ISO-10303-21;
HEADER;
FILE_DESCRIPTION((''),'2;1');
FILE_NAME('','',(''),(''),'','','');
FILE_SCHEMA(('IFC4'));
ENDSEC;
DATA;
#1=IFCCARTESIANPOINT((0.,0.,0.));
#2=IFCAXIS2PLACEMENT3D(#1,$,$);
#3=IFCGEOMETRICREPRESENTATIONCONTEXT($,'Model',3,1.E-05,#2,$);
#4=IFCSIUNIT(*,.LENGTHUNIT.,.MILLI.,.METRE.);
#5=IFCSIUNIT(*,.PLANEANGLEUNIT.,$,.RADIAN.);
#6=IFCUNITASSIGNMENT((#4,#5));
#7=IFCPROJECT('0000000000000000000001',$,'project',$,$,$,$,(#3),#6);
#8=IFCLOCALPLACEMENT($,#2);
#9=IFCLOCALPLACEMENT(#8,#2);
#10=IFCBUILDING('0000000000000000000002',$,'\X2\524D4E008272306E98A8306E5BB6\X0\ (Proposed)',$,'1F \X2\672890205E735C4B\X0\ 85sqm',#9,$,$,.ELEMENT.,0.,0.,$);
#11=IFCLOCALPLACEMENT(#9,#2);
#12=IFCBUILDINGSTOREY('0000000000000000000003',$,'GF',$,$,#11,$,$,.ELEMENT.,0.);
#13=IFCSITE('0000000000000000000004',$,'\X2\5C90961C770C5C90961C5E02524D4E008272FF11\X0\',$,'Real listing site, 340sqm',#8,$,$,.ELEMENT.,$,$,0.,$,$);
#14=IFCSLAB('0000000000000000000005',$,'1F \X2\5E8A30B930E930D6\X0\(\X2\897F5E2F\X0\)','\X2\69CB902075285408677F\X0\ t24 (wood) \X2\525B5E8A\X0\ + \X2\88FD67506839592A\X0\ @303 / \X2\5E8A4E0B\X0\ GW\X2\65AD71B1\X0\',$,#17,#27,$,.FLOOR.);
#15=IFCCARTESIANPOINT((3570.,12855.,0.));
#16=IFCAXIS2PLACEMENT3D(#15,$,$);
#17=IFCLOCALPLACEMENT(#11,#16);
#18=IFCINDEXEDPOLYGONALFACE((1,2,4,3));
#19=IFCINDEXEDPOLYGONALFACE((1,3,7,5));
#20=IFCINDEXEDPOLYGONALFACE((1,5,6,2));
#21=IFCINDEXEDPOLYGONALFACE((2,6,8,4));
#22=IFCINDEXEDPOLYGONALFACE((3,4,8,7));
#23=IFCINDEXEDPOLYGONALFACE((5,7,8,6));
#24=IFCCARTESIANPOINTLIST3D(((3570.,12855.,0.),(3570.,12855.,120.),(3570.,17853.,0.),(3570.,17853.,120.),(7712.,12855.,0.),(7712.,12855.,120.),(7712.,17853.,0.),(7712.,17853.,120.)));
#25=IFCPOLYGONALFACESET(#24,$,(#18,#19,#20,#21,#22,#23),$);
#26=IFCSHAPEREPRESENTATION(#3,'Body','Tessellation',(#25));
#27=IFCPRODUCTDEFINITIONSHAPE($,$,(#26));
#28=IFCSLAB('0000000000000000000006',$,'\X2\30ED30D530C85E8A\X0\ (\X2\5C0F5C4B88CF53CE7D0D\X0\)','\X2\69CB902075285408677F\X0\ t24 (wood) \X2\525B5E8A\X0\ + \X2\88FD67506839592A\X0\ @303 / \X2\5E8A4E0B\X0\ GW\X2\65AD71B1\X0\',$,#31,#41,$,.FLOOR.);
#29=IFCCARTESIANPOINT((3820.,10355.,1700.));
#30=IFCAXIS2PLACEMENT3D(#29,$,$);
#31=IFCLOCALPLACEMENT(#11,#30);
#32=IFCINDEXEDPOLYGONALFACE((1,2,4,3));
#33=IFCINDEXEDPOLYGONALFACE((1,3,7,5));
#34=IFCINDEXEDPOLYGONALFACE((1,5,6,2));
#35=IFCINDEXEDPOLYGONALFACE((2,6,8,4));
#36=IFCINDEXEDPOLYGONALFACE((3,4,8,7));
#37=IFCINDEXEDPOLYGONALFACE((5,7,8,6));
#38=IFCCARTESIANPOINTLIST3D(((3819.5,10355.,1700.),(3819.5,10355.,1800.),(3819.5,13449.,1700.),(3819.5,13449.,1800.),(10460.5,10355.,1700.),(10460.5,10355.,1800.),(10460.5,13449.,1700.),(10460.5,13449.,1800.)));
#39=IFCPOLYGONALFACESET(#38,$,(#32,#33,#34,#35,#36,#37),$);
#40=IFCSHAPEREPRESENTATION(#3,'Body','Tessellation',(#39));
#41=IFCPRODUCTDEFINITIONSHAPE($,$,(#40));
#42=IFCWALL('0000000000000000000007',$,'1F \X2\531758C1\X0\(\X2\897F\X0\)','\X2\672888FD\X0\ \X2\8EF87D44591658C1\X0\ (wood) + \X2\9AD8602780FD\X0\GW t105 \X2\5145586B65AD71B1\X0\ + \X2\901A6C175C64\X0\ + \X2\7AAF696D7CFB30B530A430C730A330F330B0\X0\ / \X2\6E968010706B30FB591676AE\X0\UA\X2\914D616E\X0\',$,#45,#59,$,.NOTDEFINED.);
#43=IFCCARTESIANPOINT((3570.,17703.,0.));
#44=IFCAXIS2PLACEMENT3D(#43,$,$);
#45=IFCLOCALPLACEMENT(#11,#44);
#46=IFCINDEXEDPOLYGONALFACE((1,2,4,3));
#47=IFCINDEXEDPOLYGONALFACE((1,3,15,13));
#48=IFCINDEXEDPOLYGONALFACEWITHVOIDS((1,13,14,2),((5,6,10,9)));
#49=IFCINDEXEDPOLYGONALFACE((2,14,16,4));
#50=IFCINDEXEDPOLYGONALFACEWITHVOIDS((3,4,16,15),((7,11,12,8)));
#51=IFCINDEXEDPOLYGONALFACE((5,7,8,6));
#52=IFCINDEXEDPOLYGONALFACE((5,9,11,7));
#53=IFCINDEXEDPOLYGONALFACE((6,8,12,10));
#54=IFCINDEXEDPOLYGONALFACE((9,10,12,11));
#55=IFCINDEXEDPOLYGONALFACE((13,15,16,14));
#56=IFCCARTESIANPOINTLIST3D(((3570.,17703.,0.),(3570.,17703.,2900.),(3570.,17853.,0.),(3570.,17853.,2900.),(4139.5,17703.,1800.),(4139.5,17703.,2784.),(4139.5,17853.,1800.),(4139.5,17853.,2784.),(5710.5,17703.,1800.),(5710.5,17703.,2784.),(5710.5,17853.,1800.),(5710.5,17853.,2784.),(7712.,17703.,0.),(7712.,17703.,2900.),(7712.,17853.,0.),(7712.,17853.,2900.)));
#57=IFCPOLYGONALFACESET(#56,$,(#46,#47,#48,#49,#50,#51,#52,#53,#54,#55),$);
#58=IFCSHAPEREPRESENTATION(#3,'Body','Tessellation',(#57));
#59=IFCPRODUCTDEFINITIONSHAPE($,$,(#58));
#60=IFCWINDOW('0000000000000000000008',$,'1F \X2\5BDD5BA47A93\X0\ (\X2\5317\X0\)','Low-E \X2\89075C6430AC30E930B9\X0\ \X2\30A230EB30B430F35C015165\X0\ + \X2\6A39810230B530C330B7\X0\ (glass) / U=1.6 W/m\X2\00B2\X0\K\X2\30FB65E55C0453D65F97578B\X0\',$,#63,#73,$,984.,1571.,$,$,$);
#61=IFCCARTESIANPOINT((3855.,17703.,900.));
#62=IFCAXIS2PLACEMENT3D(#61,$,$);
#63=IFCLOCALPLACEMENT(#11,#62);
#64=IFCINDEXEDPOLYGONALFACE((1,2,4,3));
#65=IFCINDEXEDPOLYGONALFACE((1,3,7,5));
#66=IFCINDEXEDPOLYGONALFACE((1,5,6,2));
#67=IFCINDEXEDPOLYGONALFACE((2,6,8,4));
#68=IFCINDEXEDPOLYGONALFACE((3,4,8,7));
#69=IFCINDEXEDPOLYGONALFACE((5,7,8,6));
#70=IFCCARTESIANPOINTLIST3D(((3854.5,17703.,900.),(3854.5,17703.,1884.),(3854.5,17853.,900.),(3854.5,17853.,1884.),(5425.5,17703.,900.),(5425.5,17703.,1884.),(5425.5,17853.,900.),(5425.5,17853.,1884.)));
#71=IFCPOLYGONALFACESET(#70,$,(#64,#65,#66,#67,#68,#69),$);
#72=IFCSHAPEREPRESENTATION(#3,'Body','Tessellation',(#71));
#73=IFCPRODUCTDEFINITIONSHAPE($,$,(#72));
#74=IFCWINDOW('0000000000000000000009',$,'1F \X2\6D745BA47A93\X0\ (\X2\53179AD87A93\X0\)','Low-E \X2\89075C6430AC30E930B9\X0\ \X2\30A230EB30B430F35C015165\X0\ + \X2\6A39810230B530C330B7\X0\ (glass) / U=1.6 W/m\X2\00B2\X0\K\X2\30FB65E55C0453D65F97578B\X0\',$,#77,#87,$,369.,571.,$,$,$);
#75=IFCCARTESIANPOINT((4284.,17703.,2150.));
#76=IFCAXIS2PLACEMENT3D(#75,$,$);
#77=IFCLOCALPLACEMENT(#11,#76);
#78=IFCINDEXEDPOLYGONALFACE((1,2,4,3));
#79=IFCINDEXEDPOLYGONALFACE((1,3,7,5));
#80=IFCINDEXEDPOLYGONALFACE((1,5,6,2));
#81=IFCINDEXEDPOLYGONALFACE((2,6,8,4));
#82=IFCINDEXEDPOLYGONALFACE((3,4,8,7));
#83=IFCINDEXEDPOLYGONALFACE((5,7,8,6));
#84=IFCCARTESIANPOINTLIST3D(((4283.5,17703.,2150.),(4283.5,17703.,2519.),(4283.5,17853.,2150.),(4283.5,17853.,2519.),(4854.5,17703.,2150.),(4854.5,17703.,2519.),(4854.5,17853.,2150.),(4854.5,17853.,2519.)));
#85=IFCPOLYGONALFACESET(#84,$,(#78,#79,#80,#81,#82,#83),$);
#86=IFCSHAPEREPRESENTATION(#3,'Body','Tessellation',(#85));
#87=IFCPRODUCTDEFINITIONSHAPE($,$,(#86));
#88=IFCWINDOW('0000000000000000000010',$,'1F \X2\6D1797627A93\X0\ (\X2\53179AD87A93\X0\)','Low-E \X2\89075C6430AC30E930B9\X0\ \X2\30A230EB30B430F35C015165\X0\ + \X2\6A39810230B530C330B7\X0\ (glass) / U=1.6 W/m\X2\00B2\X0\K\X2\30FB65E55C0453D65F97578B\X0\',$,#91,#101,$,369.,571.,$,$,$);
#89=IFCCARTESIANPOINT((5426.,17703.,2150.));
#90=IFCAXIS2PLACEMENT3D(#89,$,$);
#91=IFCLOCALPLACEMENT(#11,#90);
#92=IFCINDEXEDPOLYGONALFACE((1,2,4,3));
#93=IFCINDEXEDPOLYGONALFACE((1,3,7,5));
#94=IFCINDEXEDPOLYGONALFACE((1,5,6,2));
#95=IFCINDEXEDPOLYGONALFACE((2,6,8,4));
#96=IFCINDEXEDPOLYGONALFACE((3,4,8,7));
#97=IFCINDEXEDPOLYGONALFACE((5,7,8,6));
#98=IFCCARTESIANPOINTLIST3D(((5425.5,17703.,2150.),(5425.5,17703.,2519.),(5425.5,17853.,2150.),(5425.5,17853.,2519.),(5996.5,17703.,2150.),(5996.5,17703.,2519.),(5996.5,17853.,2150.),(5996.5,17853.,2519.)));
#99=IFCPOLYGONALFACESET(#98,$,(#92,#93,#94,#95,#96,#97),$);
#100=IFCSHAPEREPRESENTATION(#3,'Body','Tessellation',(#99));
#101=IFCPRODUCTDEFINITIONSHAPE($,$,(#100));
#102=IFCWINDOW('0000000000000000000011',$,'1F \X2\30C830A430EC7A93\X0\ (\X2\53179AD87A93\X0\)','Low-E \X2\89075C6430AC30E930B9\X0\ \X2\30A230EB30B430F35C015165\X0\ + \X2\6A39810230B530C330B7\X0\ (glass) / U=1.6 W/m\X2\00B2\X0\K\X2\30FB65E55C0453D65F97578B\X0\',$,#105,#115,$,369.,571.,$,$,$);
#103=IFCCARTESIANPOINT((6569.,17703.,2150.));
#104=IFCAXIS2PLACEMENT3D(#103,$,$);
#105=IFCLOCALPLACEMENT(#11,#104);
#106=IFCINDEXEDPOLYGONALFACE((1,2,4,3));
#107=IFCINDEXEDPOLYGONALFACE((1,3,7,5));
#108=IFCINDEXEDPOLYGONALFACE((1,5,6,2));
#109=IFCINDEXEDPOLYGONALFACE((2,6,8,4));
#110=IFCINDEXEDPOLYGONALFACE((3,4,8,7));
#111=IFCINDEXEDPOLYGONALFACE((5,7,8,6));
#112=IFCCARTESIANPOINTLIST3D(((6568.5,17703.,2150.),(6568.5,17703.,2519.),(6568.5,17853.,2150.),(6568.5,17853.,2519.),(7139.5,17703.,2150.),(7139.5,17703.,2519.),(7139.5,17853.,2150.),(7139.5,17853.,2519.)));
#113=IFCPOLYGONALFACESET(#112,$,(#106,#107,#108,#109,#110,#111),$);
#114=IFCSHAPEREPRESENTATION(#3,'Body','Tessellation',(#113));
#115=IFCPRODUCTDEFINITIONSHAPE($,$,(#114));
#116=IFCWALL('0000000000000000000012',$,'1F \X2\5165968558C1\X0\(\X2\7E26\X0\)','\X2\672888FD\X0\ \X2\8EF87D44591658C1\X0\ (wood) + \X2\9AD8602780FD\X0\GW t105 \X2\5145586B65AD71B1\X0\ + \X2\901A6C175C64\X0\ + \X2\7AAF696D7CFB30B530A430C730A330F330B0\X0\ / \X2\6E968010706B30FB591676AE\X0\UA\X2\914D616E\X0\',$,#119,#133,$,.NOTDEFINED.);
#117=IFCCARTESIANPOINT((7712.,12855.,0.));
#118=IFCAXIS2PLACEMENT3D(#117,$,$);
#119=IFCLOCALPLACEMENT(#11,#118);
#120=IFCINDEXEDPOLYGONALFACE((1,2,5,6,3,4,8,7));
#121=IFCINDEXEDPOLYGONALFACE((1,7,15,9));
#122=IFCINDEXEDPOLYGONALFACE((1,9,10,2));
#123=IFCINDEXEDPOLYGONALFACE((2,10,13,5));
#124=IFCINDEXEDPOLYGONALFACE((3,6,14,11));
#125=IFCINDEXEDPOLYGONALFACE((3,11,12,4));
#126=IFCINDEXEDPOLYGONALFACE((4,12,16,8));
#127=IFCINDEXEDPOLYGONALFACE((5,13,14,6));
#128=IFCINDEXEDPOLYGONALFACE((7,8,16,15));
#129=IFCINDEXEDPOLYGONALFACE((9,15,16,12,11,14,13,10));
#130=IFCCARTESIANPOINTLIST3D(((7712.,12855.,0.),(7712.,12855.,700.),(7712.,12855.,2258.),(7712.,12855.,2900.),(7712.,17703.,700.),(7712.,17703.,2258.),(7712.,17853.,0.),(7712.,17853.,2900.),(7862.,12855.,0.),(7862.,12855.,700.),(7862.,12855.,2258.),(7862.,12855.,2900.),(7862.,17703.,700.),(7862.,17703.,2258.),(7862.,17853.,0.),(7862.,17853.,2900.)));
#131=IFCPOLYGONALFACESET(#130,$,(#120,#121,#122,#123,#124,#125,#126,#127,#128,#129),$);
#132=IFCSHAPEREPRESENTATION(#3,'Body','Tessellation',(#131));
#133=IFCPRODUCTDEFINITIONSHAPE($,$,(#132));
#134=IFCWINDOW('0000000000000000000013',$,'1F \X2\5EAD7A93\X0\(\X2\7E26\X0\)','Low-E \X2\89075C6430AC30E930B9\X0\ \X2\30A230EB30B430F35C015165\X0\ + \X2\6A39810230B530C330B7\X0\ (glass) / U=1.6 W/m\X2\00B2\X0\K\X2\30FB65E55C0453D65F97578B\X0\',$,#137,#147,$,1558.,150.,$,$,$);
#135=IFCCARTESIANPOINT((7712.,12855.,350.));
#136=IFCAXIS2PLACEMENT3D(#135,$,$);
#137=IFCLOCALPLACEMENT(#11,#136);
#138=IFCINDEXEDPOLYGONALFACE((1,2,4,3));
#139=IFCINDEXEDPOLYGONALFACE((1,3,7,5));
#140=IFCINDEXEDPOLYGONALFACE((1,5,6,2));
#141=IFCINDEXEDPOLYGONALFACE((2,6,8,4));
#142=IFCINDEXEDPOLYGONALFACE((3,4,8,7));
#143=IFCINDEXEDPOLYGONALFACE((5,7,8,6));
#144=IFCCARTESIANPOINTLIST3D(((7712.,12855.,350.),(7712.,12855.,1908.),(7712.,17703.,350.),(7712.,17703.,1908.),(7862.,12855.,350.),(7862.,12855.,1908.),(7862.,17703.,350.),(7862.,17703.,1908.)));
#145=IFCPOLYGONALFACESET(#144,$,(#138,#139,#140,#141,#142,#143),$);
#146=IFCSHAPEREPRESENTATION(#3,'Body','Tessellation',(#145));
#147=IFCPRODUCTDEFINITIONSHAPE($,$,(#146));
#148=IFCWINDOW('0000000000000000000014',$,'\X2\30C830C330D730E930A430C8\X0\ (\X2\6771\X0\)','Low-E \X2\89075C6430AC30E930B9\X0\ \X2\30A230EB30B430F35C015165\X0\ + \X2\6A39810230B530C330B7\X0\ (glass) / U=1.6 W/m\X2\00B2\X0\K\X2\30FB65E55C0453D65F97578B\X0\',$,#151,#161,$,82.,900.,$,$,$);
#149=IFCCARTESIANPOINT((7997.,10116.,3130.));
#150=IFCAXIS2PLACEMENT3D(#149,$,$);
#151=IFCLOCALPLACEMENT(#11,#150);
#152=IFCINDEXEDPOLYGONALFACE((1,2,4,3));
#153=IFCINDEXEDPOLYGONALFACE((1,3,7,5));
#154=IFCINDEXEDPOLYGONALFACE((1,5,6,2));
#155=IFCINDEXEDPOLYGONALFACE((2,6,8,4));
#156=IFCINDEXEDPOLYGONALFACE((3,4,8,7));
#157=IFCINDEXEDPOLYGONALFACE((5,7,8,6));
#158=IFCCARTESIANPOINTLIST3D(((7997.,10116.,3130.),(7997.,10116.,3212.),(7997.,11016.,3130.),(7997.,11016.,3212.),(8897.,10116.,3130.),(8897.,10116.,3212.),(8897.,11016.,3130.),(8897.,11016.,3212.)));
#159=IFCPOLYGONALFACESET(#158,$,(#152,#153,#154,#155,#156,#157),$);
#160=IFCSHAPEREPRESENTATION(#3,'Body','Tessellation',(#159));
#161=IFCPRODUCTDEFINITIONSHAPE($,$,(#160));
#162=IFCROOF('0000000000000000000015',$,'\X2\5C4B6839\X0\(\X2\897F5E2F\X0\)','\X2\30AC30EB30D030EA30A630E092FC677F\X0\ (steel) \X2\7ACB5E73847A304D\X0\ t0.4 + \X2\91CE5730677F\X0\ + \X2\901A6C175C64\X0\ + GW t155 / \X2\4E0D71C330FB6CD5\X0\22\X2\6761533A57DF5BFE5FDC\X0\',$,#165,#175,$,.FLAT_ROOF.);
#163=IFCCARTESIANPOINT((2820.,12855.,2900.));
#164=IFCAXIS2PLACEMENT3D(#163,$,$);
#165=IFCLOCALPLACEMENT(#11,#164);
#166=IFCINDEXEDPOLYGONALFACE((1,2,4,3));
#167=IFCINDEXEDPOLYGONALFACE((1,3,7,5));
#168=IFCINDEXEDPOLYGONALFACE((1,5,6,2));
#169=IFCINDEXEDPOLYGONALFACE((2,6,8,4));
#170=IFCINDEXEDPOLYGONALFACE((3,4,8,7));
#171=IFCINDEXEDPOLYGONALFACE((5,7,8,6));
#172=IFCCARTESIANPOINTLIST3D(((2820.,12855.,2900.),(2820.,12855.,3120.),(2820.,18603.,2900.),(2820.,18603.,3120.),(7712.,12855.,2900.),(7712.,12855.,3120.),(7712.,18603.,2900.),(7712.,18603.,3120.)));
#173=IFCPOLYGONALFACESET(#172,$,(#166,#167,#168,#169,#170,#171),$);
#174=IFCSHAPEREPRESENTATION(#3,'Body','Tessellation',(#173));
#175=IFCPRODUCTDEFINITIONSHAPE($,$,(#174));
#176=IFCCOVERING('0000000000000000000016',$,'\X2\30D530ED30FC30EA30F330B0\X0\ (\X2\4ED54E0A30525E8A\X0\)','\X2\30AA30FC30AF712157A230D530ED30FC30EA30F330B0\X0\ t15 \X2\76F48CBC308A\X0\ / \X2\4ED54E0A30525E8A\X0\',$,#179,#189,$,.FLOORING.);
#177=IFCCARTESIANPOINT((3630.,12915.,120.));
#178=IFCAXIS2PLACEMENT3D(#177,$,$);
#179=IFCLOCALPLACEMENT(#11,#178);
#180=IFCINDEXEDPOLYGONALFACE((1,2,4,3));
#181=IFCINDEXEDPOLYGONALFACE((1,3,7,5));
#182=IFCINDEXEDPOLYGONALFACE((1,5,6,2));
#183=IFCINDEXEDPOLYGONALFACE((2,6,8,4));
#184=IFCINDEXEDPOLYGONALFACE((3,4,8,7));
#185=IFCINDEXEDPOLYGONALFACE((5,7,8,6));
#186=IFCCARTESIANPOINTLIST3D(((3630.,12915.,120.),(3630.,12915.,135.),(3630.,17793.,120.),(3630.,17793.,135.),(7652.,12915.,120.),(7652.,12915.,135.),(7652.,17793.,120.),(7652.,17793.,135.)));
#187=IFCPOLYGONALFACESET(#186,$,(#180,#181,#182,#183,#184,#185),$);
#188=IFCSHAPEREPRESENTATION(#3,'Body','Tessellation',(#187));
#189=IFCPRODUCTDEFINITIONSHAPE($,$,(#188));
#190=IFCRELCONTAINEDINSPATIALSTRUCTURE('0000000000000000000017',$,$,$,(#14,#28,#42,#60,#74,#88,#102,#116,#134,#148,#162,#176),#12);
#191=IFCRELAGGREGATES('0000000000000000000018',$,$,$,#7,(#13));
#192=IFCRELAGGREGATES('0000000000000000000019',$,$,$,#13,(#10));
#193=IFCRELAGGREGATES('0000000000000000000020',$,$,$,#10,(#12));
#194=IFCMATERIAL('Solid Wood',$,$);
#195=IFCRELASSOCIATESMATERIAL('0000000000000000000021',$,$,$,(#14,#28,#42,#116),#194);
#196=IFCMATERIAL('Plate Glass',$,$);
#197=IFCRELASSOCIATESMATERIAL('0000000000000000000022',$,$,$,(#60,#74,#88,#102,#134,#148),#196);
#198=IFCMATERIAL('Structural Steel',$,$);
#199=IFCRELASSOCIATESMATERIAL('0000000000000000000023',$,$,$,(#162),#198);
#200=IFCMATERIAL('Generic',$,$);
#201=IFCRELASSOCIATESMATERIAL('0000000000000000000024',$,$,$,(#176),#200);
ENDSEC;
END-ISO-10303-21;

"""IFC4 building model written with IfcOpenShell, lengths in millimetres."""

from ifc_helpers import new_model, si_unit, frame, frame_2d, origin, place, context, project, spatial, rectangle, extrude, material, element, fill, save


model = new_model("IFC4")

# Units and contexts
model_context = context("Model", 3, precision=1e-05, world=origin())
ifc_project = project(units=[si_unit("LENGTHUNIT", "METRE", prefix="MILLI"), si_unit("PLANEANGLEUNIT", "RADIAN")], contexts=[model_context])

# Site, building, storey
site_placement = place(None, origin())
site = spatial("IfcSite", under=ifc_project, at=site_placement, Name="岐阜県岐阜市前一色１", ObjectType="Real listing site, 340sqm", CompositionType="ELEMENT", RefElevation=0.0)
building_placement = place(site_placement, origin())
building = spatial("IfcBuilding", under=site, at=building_placement, Name="前一色の風の家 (Proposed)", ObjectType="1F 木造平屋 85sqm", CompositionType="ELEMENT", ElevationOfRefHeight=0.0, ElevationOfTerrain=0.0)
storey_placement = place(building_placement, origin())
storey = spatial("IfcBuildingStorey", under=building, at=storey_placement, Name="GF", CompositionType="ELEMENT", Elevation=0.0)

# Slabs
ifc_material_1 = material(Name="Solid Wood")
slab_1_placement = place(storey_placement, frame((3570.0, 12855.0, 0.0)))
element("IfcSlab", 1, at=slab_1_placement, inside=storey, material=ifc_material_1, Name="1F 床スラブ(西帯)", Description="構造用合板 t24 (wood) 剛床 + 製材根太 @303 / 床下 GW断熱", PredefinedType="FLOOR", context=model_context, shape_type="SweptSolid", body=[
    extrude(rectangle(XDim=4142.0, YDim=4998.0, at=frame_2d((2071.0, 2499.0))), frame((3570.0, 12855.0, 0.0)), (0.0, 0.0, 1.0), 120.0),
])
slab_2_placement = place(storey_placement, frame((3820.0, 10355.0, 1700.0)))
element("IfcSlab", 2, at=slab_2_placement, inside=storey, material=ifc_material_1, Name="ロフト床 (小屋裏収納)", Description="構造用合板 t24 (wood) 剛床 + 製材根太 @303 / 床下 GW断熱", PredefinedType="FLOOR", context=model_context, shape_type="SweptSolid", body=[
    extrude(rectangle(XDim=6641.0, YDim=3094.0, at=frame_2d((3320.0, 1547.0))), frame((3820.0, 10355.0, 1700.0)), (0.0, 0.0, 1.0), 100.0),
])

# Wall, openings, windows
wall_1_placement = place(storey_placement, frame((3570.0, 17703.0, 0.0)))
wall_1 = element("IfcWall", 3, at=wall_1_placement, inside=storey, material=ifc_material_1, Name="1F 北壁(西)", Description="木製 軸組外壁 (wood) + 高性能GW t105 充填断熱 + 通気層 + 窯業系サイディング / 準耐火・外皮UA配慮", PredefinedType="NOTDEFINED", context=model_context, shape_type="SweptSolid", body=[
    extrude(rectangle(XDim=4142.0, YDim=150.0, at=frame_2d((2071.0, 75.0))), frame((3570.0, 17703.0, 0.0)), (0.0, 0.0, 1.0), 2900.0),
])
opening_1_placement = place(storey_placement, frame((3855.0, 17703.0, 900.0)))
opening_1 = element("IfcOpeningElement", 4, at=opening_1_placement, cuts=wall_1, PredefinedType="NOTDEFINED", context=model_context, shape_type="SweptSolid", body=[
    extrude(rectangle(XDim=1571.0, YDim=150.0, at=frame_2d((785.0, 75.0))), frame((3855.0, 17703.0, 900.0)), (0.0, 0.0, 1.0), 984.0),
])
opening_2_placement = place(storey_placement, frame((4284.0, 17703.0, 2150.0)))
opening_2 = element("IfcOpeningElement", 5, at=opening_2_placement, cuts=wall_1, PredefinedType="NOTDEFINED", context=model_context, shape_type="SweptSolid", body=[
    extrude(rectangle(XDim=571.0, YDim=150.0, at=frame_2d((285.0, 75.0))), frame((4284.0, 17703.0, 2150.0)), (0.0, 0.0, 1.0), 369.0),
])
opening_3_placement = place(storey_placement, frame((5426.0, 17703.0, 2150.0)))
opening_3 = element("IfcOpeningElement", 6, at=opening_3_placement, cuts=wall_1, PredefinedType="NOTDEFINED", context=model_context, shape_type="SweptSolid", body=[
    extrude(rectangle(XDim=571.0, YDim=150.0, at=frame_2d((285.0, 75.0))), frame((5426.0, 17703.0, 2150.0)), (0.0, 0.0, 1.0), 369.0),
])
opening_4_placement = place(storey_placement, frame((6569.0, 17703.0, 2150.0)))
opening_4 = element("IfcOpeningElement", 7, at=opening_4_placement, cuts=wall_1, PredefinedType="NOTDEFINED", context=model_context, shape_type="SweptSolid", body=[
    extrude(rectangle(XDim=571.0, YDim=150.0, at=frame_2d((285.0, 75.0))), frame((6569.0, 17703.0, 2150.0)), (0.0, 0.0, 1.0), 369.0),
])
ifc_material_2 = material(Name="Plate Glass")
window_1_placement = place(storey_placement, frame((3855.0, 17703.0, 900.0)))
window_1 = element("IfcWindow", 8, at=window_1_placement, inside=storey, material=ifc_material_2, Name="1F 寝室窓 (北)", Description="Low-E 複層ガラス アルゴン封入 + 樹脂サッシ (glass) / U=1.6 W/m²K・日射取得型", OverallHeight=984.0, OverallWidth=1571.0, context=model_context, shape_type="SweptSolid", body=[
    extrude(rectangle(XDim=1571.0, YDim=150.0, at=frame_2d((785.0, 75.0))), frame((3855.0, 17703.0, 900.0)), (0.0, 0.0, 1.0), 984.0),
])
fill(opening_1, window_1)
window_2_placement = place(storey_placement, frame((4284.0, 17703.0, 2150.0)))
window_2 = element("IfcWindow", 9, at=window_2_placement, inside=storey, material=ifc_material_2, Name="1F 浴室窓 (北高窓)", Description="Low-E 複層ガラス アルゴン封入 + 樹脂サッシ (glass) / U=1.6 W/m²K・日射取得型", OverallHeight=369.0, OverallWidth=571.0, context=model_context, shape_type="SweptSolid", body=[
    extrude(rectangle(XDim=571.0, YDim=150.0, at=frame_2d((285.0, 75.0))), frame((4284.0, 17703.0, 2150.0)), (0.0, 0.0, 1.0), 369.0),
])
fill(opening_2, window_2)
window_3_placement = place(storey_placement, frame((5426.0, 17703.0, 2150.0)))
window_3 = element("IfcWindow", 10, at=window_3_placement, inside=storey, material=ifc_material_2, Name="1F 洗面窓 (北高窓)", Description="Low-E 複層ガラス アルゴン封入 + 樹脂サッシ (glass) / U=1.6 W/m²K・日射取得型", OverallHeight=369.0, OverallWidth=571.0, context=model_context, shape_type="SweptSolid", body=[
    extrude(rectangle(XDim=571.0, YDim=150.0, at=frame_2d((285.0, 75.0))), frame((5426.0, 17703.0, 2150.0)), (0.0, 0.0, 1.0), 369.0),
])
fill(opening_3, window_3)
window_4_placement = place(storey_placement, frame((6569.0, 17703.0, 2150.0)))
window_4 = element("IfcWindow", 11, at=window_4_placement, inside=storey, material=ifc_material_2, Name="1F トイレ窓 (北高窓)", Description="Low-E 複層ガラス アルゴン封入 + 樹脂サッシ (glass) / U=1.6 W/m²K・日射取得型", OverallHeight=369.0, OverallWidth=571.0, context=model_context, shape_type="SweptSolid", body=[
    extrude(rectangle(XDim=571.0, YDim=150.0, at=frame_2d((285.0, 75.0))), frame((6569.0, 17703.0, 2150.0)), (0.0, 0.0, 1.0), 369.0),
])
fill(opening_4, window_4)

# Wall, opening, window
wall_2_placement = place(storey_placement, frame((7712.0, 12855.0, 0.0)))
wall_2 = element("IfcWall", 12, at=wall_2_placement, inside=storey, material=ifc_material_1, Name="1F 入隅壁(縦)", Description="木製 軸組外壁 (wood) + 高性能GW t105 充填断熱 + 通気層 + 窯業系サイディング / 準耐火・外皮UA配慮", PredefinedType="NOTDEFINED", context=model_context, shape_type="SweptSolid", body=[
    extrude(rectangle(XDim=150.0, YDim=4998.0, at=frame_2d((75.0, 2499.0))), frame((7712.0, 12855.0, 0.0)), (0.0, 0.0, 1.0), 2900.0),
])
opening_5_placement = place(storey_placement, frame((7712.0, 12855.0, 350.0)))
opening_5 = element("IfcOpeningElement", 13, at=opening_5_placement, cuts=wall_2, PredefinedType="NOTDEFINED", context=model_context, shape_type="SweptSolid", body=[
    extrude(rectangle(XDim=150.0, YDim=4848.0, at=frame_2d((75.0, 2424.0))), frame((7712.0, 12855.0, 350.0)), (0.0, 0.0, 1.0), 1558.0),
])
window_5_placement = place(storey_placement, frame((7712.0, 12855.0, 350.0)))
window_5 = element("IfcWindow", 14, at=window_5_placement, inside=storey, material=ifc_material_2, Name="1F 庭窓(縦)", Description="Low-E 複層ガラス アルゴン封入 + 樹脂サッシ (glass) / U=1.6 W/m²K・日射取得型", OverallHeight=1558.0, OverallWidth=150.0, context=model_context, shape_type="SweptSolid", body=[
    extrude(rectangle(XDim=150.0, YDim=4848.0, at=frame_2d((75.0, 2424.0))), frame((7712.0, 12855.0, 350.0)), (0.0, 0.0, 1.0), 1558.0),
])
fill(opening_5, window_5)

# Window
window_6_placement = place(storey_placement, frame((7997.0, 10116.0, 3130.0)))
element("IfcWindow", 15, at=window_6_placement, inside=storey, material=ifc_material_2, Name="トップライト (東)", Description="Low-E 複層ガラス アルゴン封入 + 樹脂サッシ (glass) / U=1.6 W/m²K・日射取得型", OverallHeight=82.0, OverallWidth=900.0, context=model_context, shape_type="SweptSolid", body=[
    extrude(rectangle(XDim=900.0, YDim=900.0, at=frame_2d((450.0, 450.0))), frame((7997.0, 10116.0, 3130.0)), (0.0, 0.0, 1.0), 82.0),
])

# Roof
ifc_material_3 = material(Name="Structural Steel")
roof_placement = place(storey_placement, frame((2820.0, 12855.0, 2900.0)))
element("IfcRoof", 16, at=roof_placement, inside=storey, material=ifc_material_3, Name="屋根(西帯)", Description="ガルバリウム鋼板 (steel) 立平葺き t0.4 + 野地板 + 通気層 + GW t155 / 不燃・法22条区域対応", PredefinedType="FLAT_ROOF", context=model_context, shape_type="SweptSolid", body=[
    extrude(rectangle(XDim=4892.0, YDim=5748.0, at=frame_2d((2446.0, 2874.0))), frame((2820.0, 12855.0, 2900.0)), (0.0, 0.0, 1.0), 220.0),
])

# Covering
ifc_material_4 = material(Name="Generic")
covering_placement = place(storey_placement, frame((3630.0, 12915.0, 120.0)))
element("IfcCovering", 17, at=covering_placement, inside=storey, material=ifc_material_4, Name="フローリング (仕上げ床)", Description="オーク無垢フローリング t15 直貼り / 仕上げ床", PredefinedType="FLOORING", context=model_context, shape_type="SweptSolid", body=[
    extrude(rectangle(XDim=4022.0, YDim=4878.0, at=frame_2d((2011.0, 2439.0))), frame((3630.0, 12915.0, 120.0)), (0.0, 0.0, 1.0), 15.0),
])

save(model, "model.ifc")
